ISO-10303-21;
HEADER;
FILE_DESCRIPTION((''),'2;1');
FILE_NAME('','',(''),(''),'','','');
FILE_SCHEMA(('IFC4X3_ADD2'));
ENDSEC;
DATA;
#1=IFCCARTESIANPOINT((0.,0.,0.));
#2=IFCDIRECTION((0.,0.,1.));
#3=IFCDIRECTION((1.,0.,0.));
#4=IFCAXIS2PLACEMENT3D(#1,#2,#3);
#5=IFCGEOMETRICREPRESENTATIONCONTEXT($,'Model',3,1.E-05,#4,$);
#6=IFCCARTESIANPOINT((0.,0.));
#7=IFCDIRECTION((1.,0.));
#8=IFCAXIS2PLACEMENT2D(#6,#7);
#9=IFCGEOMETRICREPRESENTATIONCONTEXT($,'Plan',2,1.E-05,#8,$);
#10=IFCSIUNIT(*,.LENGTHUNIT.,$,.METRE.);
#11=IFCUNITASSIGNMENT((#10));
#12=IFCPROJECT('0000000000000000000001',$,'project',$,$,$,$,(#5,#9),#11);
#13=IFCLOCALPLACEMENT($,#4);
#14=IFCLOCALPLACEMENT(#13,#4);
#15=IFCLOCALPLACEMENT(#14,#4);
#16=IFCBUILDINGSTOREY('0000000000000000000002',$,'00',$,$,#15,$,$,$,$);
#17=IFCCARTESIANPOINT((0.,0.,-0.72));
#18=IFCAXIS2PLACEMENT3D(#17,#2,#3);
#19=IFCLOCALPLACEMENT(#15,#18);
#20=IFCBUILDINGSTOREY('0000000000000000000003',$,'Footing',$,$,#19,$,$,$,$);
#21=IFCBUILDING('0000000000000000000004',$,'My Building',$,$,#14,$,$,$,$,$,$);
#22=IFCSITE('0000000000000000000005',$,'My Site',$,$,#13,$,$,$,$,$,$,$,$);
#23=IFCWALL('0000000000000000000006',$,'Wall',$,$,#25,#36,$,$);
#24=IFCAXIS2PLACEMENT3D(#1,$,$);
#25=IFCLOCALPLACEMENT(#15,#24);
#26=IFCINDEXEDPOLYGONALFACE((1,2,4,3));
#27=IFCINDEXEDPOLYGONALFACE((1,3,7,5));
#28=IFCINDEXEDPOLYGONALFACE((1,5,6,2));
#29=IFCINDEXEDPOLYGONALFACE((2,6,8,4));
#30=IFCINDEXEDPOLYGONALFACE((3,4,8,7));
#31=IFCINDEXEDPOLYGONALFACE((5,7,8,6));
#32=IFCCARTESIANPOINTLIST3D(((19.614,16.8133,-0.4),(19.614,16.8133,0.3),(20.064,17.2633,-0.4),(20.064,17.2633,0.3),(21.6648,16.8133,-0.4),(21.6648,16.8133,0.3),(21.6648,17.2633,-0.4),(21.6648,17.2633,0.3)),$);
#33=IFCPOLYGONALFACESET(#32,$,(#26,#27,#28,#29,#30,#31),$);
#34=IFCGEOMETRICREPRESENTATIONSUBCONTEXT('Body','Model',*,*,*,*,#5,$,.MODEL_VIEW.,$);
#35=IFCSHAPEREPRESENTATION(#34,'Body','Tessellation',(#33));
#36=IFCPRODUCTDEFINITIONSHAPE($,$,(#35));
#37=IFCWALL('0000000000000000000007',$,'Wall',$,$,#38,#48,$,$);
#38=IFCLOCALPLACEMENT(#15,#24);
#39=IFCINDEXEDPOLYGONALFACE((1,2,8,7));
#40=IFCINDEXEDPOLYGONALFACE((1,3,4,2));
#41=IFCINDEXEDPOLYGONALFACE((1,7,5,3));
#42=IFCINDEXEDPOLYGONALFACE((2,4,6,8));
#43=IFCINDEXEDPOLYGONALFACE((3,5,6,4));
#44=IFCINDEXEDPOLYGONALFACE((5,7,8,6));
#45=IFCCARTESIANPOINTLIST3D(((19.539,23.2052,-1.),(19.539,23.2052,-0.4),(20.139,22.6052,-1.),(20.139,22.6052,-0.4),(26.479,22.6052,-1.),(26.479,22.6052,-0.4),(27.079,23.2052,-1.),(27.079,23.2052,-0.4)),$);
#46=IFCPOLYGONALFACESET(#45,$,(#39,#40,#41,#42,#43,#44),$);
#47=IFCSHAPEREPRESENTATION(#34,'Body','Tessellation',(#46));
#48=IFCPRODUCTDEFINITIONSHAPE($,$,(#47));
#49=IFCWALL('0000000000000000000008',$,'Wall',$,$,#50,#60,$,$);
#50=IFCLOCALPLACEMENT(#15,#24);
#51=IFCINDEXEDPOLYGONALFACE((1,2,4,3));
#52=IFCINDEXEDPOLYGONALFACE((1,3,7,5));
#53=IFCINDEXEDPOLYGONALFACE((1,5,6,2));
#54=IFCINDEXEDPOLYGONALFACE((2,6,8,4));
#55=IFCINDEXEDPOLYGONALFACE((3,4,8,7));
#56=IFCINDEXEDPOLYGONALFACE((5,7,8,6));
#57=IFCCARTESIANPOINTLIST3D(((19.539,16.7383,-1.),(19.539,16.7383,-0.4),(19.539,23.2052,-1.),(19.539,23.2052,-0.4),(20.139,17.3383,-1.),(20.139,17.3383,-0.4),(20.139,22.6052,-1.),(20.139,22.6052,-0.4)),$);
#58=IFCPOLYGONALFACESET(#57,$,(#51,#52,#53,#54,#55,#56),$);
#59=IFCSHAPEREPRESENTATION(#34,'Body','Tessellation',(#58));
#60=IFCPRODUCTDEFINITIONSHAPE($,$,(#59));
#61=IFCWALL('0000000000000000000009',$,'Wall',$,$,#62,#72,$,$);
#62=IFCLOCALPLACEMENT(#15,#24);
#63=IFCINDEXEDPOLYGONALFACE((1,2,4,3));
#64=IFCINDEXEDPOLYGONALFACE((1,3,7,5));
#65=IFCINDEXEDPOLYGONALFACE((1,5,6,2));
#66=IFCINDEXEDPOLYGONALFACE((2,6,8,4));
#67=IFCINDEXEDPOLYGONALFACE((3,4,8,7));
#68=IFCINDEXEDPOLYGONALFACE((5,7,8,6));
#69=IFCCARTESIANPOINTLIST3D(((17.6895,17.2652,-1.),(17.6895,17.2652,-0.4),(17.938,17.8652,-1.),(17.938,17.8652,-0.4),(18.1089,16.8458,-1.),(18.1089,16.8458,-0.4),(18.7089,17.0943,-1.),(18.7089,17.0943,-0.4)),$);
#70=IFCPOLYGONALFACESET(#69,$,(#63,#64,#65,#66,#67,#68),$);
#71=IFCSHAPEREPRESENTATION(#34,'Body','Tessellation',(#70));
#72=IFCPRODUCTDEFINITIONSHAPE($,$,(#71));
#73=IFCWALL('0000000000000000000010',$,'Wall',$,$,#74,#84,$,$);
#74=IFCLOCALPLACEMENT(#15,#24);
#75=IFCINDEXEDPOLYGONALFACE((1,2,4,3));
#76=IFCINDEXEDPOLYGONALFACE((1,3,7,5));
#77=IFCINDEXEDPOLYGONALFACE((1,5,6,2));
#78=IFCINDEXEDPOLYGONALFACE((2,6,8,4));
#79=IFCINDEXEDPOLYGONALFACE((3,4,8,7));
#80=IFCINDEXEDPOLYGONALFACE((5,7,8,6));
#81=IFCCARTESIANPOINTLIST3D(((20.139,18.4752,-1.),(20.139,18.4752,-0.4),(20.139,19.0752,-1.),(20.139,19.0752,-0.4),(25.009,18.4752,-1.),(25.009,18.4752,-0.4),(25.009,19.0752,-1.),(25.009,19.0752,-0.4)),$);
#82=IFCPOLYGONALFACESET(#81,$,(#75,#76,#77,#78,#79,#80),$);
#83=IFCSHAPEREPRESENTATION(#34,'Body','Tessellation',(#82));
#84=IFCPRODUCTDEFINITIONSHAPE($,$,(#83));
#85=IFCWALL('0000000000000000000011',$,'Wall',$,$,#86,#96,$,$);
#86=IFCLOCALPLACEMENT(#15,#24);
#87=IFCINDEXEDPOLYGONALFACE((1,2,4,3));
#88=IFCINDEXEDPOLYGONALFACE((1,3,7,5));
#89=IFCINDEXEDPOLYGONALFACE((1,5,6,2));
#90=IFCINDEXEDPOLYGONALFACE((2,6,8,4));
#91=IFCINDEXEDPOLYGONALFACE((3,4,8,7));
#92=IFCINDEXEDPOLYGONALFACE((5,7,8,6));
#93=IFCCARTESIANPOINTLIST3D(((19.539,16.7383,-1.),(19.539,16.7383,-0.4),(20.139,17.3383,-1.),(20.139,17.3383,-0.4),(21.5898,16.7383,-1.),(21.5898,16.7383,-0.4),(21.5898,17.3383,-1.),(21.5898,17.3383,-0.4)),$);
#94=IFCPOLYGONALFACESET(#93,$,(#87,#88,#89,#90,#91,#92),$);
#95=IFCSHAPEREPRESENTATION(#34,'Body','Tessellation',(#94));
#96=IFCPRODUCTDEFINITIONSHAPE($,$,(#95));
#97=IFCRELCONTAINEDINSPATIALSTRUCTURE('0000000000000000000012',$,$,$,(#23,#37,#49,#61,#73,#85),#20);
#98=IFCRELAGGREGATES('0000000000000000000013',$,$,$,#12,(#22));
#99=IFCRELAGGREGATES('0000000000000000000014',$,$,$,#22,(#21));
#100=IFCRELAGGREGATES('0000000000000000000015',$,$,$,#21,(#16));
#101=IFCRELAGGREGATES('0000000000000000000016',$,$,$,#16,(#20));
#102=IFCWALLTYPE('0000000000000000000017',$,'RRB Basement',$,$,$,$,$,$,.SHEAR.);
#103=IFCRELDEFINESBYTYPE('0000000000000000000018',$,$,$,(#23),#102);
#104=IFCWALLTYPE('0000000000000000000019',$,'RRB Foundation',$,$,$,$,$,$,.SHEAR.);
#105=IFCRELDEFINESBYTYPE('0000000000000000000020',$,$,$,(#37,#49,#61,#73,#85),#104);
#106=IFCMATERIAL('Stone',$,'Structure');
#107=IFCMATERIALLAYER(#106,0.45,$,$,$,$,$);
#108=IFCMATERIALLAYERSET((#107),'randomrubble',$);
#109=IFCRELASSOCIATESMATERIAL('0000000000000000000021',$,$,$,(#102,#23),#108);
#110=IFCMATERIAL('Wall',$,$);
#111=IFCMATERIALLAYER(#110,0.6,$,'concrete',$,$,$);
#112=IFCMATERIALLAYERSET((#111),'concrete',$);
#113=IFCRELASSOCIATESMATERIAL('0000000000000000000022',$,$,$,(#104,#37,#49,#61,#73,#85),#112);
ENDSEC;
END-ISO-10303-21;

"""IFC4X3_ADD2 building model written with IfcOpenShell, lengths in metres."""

from ifc_helpers import new_model, si_unit, frame, origin_with_axes, origin_2d_with_axis, place, context, subcontext, project, spatial, line, indexed_curve, outline, extrude, material, layer, layer_set, layer_usage, type_object, element, save


model = new_model("IFC4X3_ADD2")

# Units and contexts
model_context = context("Model", 3, precision=1e-05, world=origin_with_axes())
plan_context = context("Plan", 2, precision=1e-05, world=origin_2d_with_axis())
body_context = subcontext(model_context, "Body", "Model", "MODEL_VIEW")
ifc_project = project(units=[si_unit("LENGTHUNIT", "METRE")], contexts=[model_context, plan_context])

# Site, building, storeys
site_placement = place(None, origin_with_axes())
site = spatial("IfcSite", under=ifc_project, at=site_placement, Name="My Site")
building_placement = place(site_placement, origin_with_axes())
building = spatial("IfcBuilding", under=site, at=building_placement, Name="My Building")
storey_1_placement = place(building_placement, origin_with_axes())
storey_1 = spatial("IfcBuildingStorey", under=building, at=storey_1_placement, Name="00")
storey_2_placement = place(storey_1_placement, frame((0.0, 0.0, -0.72), z_axis=(0.0, 0.0, 1.0), x_axis=(1.0, 0.0, 0.0)))
storey_2 = spatial("IfcBuildingStorey", under=storey_1, at=storey_2_placement, Name="Footing")

# Shared definitions
ifc_material_1 = material(Name="Stone", Category="Structure")

# Walls
ifc_material_2 = material(Name="Wall")
ifc_layer_1 = layer(ifc_material_1, 0.45)
ifc_layer_set_1 = layer_set([ifc_layer_1], Name="randomrubble")
wall_type_1 = type_object("IfcWallType", Name="RRB Basement", PredefinedType="SHEAR", material=ifc_layer_set_1)
ifc_layer_usage_1 = layer_usage(ifc_layer_set_1, "AXIS2", "POSITIVE", 0.0)
wall_1_placement = place(storey_2_placement, frame((19.614, 16.8133, 0.32), z_axis=(0.0, 0.0, 1.0), x_axis=(1.0, 0.0, 0.0)))
element("IfcWall", 1, at=wall_1_placement, inside=storey_2, type_object=wall_type_1, material=ifc_layer_usage_1, Name="Wall", context=body_context, shape_type="SweptSolid", body=[
    extrude(outline(indexed_curve([(0.0, 0.0), (0.45, 0.45), (2.0508, 0.45), (2.0508, 0.0)], segments=[line(1, 2, 3, 4, 1)])), origin_with_axes(), (0.0, 0.0, 1.0), 0.7),
])
ifc_layer_2 = layer(ifc_material_2, 0.6, Name="concrete")
ifc_layer_set_2 = layer_set([ifc_layer_2], Name="concrete")
ifc_layer_usage_2 = layer_usage(ifc_layer_set_2, "AXIS2", "POSITIVE", 0.0)
wall_type_2 = type_object("IfcWallType", Name="RRB Foundation", PredefinedType="SHEAR", material=ifc_layer_set_2)
wall_2_placement = place(storey_2_placement, frame((20.139, 22.6052, -0.28), z_axis=(0.0, 0.0, 1.0), x_axis=(1.0, 0.0, 0.0)))
element("IfcWall", 2, at=wall_2_placement, inside=storey_2, type_object=wall_type_2, material=ifc_layer_usage_2, Name="Wall", context=body_context, shape_type="SweptSolid", body=[
    extrude(outline(indexed_curve([(0.0, 0.0), (-0.6, 0.6), (6.94, 0.6), (6.34, 0.0)], segments=[line(1, 2, 3, 4, 1)])), origin_with_axes(), (0.0, 0.0, 1.0), 0.6),
])
ifc_layer_usage_3 = layer_usage(ifc_layer_set_2, "AXIS2", "POSITIVE", 0.0)
wall_3_placement = place(storey_2_placement, frame((20.139, 16.7383, -0.28), z_axis=(0.0, 0.0, 1.0), x_axis=(0.000001, 1.0, 0.0)))
element("IfcWall", 3, at=wall_3_placement, inside=storey_2, type_object=wall_type_2, material=ifc_layer_usage_3, Name="Wall", context=body_context, shape_type="SweptSolid", body=[
    extrude(outline(indexed_curve([(0.6, 0.0), (0.0, 0.6), (6.4669, 0.6), (5.8669, 0.0)], segments=[line(1, 2, 3, 4, 1)])), origin_with_axes(), (0.0, 0.0, 1.0), 0.6),
])
ifc_layer_usage_4 = layer_usage(ifc_layer_set_2, "AXIS2", "POSITIVE", 0.0)
wall_4_placement = place(storey_2_placement, frame((18.7089, 17.0943, -0.28), z_axis=(0.0, 0.0, 1.0), x_axis=(-0.707107, 0.707107, 0.0)))
element("IfcWall", 4, at=wall_4_placement, inside=storey_2, type_object=wall_type_2, material=ifc_layer_usage_4, Name="Wall", context=body_context, shape_type="SweptSolid", body=[
    extrude(outline(indexed_curve([(0.0, 0.0), (0.2485, 0.6), (0.8417, 0.6), (1.0902, 0.0)], segments=[line(1, 2, 3, 4, 1)])), origin_with_axes(), (0.0, 0.0, 1.0), 0.6),
])
ifc_layer_usage_5 = layer_usage(ifc_layer_set_2, "AXIS2", "POSITIVE", 0.0)
wall_5_placement = place(storey_2_placement, frame((20.139, 18.4752, -0.28), z_axis=(0.0, 0.0, 1.0), x_axis=(1.0, 0.0, 0.0)))
element("IfcWall", 5, at=wall_5_placement, inside=storey_2, type_object=wall_type_2, material=ifc_layer_usage_5, Name="Wall", context=body_context, shape_type="SweptSolid", body=[
    extrude(outline(indexed_curve([(0.0, 0.0), (0.0, 0.6), (4.87, 0.6), (4.87, 0.0)], segments=[line(1, 2, 3, 4, 1)])), origin_with_axes(), (0.0, 0.0, 1.0), 0.6),
])
ifc_layer_usage_6 = layer_usage(ifc_layer_set_2, "AXIS2", "POSITIVE", 0.0)
wall_6_placement = place(storey_2_placement, frame((20.139, 16.7383, -0.28), z_axis=(0.0, 0.0, 1.0), x_axis=(1.0, 0.0, 0.0)))
element("IfcWall", 6, at=wall_6_placement, inside=storey_2, type_object=wall_type_2, material=ifc_layer_usage_6, Name="Wall", context=body_context, shape_type="SweptSolid", body=[
    extrude(outline(indexed_curve([(-0.6, 0.0), (0.0, 0.6), (1.4508, 0.6), (1.4508, 0.0)], segments=[line(1, 2, 3, 4, 1)])), origin_with_axes(), (0.0, 0.0, 1.0), 0.6),
])

save(model, "model.ifc")
